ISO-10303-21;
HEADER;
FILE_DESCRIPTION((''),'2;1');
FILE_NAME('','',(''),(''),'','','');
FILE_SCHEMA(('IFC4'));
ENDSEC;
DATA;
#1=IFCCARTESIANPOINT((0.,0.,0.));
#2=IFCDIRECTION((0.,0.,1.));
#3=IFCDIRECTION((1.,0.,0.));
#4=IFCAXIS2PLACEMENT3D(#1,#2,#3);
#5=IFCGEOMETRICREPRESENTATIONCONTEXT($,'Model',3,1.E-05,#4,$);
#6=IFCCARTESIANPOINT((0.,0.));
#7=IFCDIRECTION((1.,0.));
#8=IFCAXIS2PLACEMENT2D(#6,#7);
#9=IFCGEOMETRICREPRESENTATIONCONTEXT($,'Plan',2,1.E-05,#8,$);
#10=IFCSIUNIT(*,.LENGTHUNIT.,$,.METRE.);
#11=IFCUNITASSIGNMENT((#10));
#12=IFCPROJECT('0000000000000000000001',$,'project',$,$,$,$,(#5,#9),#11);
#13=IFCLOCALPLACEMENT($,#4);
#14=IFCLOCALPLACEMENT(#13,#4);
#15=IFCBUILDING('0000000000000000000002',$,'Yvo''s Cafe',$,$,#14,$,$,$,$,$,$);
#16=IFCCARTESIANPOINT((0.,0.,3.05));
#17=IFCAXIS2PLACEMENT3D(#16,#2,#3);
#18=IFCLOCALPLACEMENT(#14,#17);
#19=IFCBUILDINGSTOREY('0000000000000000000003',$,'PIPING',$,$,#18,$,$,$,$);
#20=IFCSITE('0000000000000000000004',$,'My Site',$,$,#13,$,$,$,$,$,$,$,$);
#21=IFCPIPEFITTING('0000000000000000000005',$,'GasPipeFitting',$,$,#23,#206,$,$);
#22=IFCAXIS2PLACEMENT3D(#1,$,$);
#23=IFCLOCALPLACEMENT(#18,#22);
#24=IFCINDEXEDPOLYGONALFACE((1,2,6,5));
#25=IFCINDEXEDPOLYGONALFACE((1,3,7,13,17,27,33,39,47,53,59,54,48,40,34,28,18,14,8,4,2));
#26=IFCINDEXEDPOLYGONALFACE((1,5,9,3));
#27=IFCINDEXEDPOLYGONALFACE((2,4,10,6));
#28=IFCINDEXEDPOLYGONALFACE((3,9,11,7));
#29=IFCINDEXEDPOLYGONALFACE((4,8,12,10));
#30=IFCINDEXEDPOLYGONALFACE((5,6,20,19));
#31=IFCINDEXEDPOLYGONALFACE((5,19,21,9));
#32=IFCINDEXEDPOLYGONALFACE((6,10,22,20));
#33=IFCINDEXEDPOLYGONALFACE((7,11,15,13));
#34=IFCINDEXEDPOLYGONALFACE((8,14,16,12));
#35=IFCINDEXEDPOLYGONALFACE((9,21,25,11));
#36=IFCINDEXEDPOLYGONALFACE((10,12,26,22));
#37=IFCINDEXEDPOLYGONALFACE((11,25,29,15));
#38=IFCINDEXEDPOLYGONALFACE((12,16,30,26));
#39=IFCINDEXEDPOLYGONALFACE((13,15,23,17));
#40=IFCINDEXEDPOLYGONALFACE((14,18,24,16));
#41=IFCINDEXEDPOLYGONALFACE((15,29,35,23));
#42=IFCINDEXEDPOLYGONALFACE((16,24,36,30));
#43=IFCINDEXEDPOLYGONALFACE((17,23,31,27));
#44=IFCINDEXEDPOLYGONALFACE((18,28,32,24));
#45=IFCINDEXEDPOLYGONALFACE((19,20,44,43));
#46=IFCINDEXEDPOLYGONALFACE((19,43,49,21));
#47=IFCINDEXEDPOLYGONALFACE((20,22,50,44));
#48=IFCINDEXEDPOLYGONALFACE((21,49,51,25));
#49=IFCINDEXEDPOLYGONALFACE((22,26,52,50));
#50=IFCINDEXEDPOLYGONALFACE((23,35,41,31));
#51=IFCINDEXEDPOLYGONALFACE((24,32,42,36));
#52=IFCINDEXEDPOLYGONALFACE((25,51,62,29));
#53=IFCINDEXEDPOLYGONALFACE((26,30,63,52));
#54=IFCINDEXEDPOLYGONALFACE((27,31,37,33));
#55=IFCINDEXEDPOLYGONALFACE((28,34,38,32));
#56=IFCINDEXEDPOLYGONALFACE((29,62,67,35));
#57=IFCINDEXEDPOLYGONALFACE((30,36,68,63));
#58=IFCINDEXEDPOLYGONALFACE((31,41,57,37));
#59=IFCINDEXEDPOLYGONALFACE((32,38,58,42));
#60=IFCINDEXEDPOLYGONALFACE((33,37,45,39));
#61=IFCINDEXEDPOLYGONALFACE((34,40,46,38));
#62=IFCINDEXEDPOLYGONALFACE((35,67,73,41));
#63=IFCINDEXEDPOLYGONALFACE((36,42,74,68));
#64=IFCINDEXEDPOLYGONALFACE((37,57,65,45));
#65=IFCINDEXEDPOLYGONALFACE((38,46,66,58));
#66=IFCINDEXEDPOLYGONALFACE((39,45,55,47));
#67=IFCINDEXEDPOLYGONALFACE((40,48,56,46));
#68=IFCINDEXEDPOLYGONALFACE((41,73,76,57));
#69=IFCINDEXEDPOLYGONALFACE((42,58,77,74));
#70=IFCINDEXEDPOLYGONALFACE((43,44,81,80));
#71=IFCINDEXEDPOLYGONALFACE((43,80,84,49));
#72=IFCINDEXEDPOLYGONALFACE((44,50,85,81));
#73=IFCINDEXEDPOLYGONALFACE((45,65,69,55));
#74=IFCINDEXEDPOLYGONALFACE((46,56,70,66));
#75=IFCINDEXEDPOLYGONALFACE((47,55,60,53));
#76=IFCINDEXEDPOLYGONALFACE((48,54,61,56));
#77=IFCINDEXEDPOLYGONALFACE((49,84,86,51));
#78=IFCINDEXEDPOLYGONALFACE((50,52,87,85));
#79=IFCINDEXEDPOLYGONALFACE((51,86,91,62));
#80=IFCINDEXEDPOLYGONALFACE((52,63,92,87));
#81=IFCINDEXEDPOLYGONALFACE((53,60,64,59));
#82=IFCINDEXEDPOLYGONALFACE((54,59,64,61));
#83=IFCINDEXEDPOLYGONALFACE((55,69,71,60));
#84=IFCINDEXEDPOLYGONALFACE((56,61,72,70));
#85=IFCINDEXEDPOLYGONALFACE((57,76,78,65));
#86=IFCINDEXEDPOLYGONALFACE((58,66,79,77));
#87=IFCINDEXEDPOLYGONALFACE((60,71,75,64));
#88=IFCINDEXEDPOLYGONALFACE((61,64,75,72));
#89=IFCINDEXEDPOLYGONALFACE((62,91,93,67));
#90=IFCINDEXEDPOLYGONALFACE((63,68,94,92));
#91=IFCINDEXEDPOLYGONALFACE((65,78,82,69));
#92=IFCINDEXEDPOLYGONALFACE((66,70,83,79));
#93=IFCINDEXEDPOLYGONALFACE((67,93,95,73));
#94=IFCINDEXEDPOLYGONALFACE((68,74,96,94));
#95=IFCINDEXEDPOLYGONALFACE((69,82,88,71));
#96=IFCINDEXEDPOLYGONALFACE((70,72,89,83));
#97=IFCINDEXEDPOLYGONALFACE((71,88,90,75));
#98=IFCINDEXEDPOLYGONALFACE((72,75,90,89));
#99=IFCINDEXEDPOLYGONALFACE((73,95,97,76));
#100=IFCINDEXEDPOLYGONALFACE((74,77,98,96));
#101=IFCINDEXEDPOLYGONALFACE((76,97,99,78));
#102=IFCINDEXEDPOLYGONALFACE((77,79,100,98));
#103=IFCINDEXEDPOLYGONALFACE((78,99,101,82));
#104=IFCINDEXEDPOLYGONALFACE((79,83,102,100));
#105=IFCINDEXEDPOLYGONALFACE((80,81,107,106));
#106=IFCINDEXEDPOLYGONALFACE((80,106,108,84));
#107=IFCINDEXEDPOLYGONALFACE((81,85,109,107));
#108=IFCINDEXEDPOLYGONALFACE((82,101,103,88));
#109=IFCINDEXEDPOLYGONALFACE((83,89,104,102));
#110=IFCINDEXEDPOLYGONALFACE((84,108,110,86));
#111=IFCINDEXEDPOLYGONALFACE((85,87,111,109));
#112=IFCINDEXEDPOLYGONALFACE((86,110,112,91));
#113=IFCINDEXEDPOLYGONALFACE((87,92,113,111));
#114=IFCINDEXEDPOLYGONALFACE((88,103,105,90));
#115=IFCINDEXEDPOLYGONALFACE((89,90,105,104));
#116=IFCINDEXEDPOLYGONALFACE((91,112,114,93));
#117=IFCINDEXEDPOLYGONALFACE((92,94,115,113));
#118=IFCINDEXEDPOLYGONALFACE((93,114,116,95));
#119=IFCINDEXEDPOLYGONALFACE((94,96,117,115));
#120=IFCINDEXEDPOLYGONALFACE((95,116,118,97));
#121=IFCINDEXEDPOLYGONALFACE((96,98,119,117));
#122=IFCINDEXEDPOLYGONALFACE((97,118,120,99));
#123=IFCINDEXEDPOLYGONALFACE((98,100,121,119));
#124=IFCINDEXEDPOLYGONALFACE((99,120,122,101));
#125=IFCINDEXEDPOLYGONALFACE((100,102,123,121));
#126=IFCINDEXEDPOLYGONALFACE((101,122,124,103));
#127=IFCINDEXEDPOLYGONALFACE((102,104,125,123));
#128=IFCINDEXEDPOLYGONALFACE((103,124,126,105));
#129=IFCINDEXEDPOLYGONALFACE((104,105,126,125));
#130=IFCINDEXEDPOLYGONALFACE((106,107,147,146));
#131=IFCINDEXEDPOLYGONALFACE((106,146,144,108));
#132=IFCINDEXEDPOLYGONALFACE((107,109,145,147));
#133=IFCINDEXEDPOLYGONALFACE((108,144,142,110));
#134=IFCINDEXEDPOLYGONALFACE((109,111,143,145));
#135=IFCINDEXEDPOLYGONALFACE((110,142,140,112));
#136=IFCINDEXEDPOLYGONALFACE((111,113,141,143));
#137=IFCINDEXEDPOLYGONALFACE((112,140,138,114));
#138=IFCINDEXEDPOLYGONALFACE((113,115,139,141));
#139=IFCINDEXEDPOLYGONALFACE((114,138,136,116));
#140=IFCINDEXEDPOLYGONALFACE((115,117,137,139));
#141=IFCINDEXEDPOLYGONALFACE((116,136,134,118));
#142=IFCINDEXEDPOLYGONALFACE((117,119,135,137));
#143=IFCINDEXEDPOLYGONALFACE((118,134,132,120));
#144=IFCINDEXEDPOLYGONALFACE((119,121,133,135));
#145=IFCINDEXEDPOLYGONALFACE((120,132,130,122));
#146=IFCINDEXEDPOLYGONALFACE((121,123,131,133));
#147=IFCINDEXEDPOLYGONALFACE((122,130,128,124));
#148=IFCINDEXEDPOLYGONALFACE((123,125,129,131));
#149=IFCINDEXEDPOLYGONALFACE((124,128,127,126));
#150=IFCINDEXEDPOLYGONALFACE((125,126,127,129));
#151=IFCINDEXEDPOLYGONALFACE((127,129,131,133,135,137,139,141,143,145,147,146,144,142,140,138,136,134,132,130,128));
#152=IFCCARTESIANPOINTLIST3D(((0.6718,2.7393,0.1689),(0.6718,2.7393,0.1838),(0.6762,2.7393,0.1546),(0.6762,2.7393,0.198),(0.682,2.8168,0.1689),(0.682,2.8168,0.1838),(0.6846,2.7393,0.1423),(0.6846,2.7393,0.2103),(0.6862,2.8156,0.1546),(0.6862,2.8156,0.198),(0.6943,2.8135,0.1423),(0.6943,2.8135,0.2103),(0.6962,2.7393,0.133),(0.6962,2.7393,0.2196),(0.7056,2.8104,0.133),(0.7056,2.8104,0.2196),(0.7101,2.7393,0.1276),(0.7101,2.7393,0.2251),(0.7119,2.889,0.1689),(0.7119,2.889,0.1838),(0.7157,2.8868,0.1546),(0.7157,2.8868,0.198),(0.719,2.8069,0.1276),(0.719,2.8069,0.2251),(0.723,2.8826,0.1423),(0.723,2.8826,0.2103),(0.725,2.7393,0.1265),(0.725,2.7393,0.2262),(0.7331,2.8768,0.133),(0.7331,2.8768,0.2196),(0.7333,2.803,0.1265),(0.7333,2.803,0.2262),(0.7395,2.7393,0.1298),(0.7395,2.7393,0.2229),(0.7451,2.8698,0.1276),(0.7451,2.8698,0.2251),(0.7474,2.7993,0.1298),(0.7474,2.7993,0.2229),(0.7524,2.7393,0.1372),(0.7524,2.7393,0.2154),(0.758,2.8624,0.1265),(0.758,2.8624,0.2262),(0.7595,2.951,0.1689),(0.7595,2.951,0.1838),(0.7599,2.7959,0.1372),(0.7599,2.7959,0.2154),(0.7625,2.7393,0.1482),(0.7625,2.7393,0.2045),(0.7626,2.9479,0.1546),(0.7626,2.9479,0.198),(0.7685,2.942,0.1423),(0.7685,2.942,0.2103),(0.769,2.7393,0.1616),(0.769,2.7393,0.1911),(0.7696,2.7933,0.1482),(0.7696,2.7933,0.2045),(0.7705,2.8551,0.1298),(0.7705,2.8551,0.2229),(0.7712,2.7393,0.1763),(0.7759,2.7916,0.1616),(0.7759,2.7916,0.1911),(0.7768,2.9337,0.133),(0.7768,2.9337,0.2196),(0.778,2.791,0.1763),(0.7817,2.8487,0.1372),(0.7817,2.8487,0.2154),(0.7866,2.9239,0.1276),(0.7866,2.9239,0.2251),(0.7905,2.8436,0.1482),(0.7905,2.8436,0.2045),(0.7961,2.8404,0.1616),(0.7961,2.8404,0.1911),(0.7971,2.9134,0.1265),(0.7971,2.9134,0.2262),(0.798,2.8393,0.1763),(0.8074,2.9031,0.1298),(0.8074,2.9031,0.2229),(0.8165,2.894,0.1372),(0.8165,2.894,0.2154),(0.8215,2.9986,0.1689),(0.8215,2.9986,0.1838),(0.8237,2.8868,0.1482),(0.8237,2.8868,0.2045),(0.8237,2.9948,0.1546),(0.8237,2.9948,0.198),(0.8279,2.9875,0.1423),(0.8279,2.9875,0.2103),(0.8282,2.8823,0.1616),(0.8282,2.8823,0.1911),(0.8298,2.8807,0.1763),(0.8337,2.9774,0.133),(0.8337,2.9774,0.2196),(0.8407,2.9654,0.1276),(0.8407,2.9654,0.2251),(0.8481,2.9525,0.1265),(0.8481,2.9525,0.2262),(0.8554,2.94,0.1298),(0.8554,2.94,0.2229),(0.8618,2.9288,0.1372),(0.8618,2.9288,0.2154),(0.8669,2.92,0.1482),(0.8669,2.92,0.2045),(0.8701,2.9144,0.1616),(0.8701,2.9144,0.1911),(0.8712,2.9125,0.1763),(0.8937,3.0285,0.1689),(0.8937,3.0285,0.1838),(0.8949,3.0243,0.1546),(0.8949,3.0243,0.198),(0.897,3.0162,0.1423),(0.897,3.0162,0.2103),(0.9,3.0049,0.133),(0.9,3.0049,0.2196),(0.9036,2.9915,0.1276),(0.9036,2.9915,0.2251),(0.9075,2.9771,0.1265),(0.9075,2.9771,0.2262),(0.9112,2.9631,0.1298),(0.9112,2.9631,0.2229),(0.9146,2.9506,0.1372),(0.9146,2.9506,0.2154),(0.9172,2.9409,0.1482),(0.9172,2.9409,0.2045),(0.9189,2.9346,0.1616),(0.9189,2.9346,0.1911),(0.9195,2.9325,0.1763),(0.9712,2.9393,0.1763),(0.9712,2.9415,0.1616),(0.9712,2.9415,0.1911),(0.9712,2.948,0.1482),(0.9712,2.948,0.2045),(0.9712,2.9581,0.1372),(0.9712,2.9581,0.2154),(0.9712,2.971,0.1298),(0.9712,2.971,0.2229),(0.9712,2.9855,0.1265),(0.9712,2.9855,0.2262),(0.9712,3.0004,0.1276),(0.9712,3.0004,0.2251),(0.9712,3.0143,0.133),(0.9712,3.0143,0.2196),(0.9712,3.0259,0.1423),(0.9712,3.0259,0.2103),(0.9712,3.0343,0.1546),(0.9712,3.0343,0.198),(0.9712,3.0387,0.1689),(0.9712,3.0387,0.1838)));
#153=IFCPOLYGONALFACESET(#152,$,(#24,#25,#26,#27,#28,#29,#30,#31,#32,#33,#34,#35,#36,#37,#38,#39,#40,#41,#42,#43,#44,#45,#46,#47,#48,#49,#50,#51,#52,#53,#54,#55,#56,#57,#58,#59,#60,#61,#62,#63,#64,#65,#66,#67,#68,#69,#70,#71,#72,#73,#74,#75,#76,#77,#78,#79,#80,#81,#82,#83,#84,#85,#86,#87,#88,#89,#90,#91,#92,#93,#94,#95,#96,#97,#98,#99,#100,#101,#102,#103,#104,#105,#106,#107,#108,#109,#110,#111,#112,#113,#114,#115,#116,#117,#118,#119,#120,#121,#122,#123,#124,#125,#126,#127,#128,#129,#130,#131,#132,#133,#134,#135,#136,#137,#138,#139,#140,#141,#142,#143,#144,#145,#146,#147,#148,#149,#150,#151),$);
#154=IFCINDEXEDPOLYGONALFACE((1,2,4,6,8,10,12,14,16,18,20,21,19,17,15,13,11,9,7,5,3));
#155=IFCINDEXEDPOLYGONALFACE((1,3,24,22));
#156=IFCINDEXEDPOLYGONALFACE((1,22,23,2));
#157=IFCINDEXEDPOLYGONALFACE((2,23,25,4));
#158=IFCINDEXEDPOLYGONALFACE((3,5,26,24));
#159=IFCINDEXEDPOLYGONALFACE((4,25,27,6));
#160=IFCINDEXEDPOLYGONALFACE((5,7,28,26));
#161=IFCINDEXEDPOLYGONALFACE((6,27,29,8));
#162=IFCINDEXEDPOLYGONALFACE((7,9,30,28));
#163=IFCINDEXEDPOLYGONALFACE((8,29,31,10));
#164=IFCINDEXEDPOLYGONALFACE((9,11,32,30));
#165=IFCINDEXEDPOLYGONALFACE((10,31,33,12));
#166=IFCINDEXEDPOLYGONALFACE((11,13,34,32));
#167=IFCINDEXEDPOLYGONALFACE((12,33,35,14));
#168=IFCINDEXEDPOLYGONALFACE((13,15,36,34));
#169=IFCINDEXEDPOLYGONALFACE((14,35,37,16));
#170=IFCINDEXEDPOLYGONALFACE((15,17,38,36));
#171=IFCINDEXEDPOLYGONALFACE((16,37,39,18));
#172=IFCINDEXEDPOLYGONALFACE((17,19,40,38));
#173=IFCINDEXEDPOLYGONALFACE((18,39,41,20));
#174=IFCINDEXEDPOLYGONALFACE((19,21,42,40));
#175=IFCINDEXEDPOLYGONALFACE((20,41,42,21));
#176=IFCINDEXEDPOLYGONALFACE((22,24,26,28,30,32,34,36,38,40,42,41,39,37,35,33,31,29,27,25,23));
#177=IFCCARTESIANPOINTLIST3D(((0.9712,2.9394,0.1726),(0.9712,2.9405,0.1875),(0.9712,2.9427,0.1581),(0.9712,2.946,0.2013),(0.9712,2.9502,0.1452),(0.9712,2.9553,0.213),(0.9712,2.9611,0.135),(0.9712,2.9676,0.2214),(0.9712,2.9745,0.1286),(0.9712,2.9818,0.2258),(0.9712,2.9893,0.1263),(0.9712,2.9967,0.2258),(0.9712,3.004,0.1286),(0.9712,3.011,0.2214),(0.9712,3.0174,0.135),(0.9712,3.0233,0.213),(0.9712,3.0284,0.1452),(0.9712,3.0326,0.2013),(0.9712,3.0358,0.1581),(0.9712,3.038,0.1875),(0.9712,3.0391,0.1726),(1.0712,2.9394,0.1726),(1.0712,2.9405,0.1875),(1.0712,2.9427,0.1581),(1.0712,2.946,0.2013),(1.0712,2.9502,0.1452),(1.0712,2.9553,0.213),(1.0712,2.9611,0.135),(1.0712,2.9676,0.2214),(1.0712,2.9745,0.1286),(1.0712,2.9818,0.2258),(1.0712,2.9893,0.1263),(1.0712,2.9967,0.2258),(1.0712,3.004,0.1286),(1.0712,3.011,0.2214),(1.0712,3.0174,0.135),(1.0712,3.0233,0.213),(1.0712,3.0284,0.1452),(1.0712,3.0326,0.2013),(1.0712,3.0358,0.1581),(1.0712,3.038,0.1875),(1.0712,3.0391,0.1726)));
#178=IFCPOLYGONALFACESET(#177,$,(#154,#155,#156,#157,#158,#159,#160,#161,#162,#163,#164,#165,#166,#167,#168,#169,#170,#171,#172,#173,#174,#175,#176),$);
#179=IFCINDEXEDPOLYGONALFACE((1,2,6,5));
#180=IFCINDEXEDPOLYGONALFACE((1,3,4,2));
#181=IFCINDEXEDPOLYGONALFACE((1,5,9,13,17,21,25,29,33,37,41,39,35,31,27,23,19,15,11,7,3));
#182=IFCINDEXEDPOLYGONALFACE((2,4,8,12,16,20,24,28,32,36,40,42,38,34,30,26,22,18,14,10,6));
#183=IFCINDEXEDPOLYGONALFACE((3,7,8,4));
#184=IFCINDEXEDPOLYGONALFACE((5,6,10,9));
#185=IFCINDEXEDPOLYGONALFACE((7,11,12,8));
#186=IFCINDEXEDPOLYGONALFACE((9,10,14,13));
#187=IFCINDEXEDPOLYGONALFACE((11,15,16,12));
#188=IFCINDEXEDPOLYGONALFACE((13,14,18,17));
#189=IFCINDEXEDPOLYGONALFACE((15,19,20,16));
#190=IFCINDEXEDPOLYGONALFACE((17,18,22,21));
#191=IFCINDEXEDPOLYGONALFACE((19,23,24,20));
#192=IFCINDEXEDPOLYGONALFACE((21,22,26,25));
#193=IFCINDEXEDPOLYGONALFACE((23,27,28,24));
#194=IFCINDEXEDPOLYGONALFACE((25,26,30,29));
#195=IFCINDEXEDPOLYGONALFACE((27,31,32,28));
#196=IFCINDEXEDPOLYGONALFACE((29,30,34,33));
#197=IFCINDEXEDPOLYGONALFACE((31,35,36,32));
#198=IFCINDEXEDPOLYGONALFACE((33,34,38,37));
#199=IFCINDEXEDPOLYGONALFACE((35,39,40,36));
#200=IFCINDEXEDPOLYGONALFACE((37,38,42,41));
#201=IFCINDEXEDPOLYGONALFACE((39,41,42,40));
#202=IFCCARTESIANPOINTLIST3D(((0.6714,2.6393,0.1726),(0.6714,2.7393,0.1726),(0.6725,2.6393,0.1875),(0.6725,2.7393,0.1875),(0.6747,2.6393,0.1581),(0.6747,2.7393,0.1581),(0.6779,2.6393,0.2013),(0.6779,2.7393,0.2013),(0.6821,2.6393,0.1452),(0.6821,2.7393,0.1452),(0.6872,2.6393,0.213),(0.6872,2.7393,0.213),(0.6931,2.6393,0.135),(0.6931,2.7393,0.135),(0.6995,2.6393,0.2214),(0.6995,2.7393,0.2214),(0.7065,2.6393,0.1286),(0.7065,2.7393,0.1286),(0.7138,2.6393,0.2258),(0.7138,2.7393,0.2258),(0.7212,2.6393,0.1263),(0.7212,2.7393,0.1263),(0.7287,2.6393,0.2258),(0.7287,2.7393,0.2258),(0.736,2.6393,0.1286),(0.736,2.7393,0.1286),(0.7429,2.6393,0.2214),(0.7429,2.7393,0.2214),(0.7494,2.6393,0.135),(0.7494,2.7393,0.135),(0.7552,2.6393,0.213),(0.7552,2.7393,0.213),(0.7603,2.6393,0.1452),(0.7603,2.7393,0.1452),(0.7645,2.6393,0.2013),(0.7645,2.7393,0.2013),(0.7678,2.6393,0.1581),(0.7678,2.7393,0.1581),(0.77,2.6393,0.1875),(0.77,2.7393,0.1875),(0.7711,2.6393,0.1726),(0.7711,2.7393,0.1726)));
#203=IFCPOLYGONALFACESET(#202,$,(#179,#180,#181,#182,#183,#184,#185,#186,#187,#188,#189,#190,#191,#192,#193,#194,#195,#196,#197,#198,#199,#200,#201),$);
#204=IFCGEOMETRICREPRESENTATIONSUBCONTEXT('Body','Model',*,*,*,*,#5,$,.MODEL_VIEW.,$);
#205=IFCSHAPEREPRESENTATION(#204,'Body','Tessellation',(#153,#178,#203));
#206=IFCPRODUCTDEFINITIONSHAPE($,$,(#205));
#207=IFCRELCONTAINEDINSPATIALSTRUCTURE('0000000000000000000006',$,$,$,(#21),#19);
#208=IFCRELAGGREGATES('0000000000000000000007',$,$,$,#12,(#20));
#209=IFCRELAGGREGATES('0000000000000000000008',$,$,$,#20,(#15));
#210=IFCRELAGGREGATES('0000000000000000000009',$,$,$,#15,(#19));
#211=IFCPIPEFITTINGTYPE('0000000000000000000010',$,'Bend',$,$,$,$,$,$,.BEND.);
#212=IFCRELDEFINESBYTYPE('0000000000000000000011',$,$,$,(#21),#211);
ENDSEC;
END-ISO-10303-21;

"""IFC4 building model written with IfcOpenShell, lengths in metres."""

from ifc_helpers import new_model, entity, si_unit, frame, origin_with_axes, origin_2d_with_axis, place, context, subcontext, project, spatial, circle, extrude, source, transform, mapped, type_object, type_shapes, element, save


model = new_model("IFC4")

# Units and contexts
model_context = context("Model", 3, precision=1e-05, world=origin_with_axes())
plan_context = context("Plan", 2, precision=1e-05, world=origin_2d_with_axis())
body_context = subcontext(model_context, "Body", "Model", "MODEL_VIEW")
ifc_project = project(units=[si_unit("LENGTHUNIT", "METRE")], contexts=[model_context, plan_context])

# Site, building, storey
site_placement = place(None, origin_with_axes())
site = spatial("IfcSite", under=ifc_project, at=site_placement, Name="My Site")
building_placement = place(site_placement, origin_with_axes())
building = spatial("IfcBuilding", under=site, at=building_placement, Name="Yvo's Cafe")
storey_placement = place(building_placement, frame((0.0, 0.0, 3.05), z_axis=(0.0, 0.0, 1.0), x_axis=(1.0, 0.0, 0.0)))
storey = spatial("IfcBuildingStorey", under=building, at=storey_placement, Name="PIPING")

# Shared definitions
pipe_fitting_type_1 = type_object("IfcPipeFittingType", Name="Bend", PredefinedType="BEND")
shared_shape_1 = source(origin_with_axes(), body_context, "Body", "SolidModel", [
    entity("IfcSweptDiskSolid", entity("IfcIndexedPolyCurve", entity("IfcCartesianPointList3D", [[0.0, 0.0, -0.1], [0.0, -0.0732, -0.2768], [0.0, -0.25, -0.35]]), [entity("IfcArcIndex", [1, 2, 3])]), 0.05),
    extrude(circle(Radius=0.05), origin_with_axes(), (0.0, 0.0, -1.0), 0.1),
    extrude(circle(Radius=0.05), frame((0.0, -0.25, -0.35), z_axis=(0.0, -1.0, 0.0), x_axis=(1.0, 0.0, 0.0)), (0.0, 0.0, 1.0), 0.1),
])
type_shapes(pipe_fitting_type_1, [shared_shape_1])

# Pipe fitting
for number, where, z_axis, x_axis, name in (
    (1, (1.0712, 2.9893, 0.1763), (1.0, 0.0, 0.0), (0.0, 0.0, -1.0), "GasPipeFitting"),
):
    element("IfcPipeFitting", number, at=place(storey_placement, frame(where, z_axis=z_axis, x_axis=x_axis)), inside=storey, type_object=pipe_fitting_type_1, Name=name, context=body_context, shape_type="MappedRepresentation", body=[
        mapped(shared_shape_1, transform((0.0, 0.0, 0.0), x_axis=(1.0, 0.0, 0.0), y_axis=(0.0, 1.0, 0.0), z_axis=(0.0, 0.0, 1.0), scale=1.0)),
    ])

save(model, "model.ifc")
